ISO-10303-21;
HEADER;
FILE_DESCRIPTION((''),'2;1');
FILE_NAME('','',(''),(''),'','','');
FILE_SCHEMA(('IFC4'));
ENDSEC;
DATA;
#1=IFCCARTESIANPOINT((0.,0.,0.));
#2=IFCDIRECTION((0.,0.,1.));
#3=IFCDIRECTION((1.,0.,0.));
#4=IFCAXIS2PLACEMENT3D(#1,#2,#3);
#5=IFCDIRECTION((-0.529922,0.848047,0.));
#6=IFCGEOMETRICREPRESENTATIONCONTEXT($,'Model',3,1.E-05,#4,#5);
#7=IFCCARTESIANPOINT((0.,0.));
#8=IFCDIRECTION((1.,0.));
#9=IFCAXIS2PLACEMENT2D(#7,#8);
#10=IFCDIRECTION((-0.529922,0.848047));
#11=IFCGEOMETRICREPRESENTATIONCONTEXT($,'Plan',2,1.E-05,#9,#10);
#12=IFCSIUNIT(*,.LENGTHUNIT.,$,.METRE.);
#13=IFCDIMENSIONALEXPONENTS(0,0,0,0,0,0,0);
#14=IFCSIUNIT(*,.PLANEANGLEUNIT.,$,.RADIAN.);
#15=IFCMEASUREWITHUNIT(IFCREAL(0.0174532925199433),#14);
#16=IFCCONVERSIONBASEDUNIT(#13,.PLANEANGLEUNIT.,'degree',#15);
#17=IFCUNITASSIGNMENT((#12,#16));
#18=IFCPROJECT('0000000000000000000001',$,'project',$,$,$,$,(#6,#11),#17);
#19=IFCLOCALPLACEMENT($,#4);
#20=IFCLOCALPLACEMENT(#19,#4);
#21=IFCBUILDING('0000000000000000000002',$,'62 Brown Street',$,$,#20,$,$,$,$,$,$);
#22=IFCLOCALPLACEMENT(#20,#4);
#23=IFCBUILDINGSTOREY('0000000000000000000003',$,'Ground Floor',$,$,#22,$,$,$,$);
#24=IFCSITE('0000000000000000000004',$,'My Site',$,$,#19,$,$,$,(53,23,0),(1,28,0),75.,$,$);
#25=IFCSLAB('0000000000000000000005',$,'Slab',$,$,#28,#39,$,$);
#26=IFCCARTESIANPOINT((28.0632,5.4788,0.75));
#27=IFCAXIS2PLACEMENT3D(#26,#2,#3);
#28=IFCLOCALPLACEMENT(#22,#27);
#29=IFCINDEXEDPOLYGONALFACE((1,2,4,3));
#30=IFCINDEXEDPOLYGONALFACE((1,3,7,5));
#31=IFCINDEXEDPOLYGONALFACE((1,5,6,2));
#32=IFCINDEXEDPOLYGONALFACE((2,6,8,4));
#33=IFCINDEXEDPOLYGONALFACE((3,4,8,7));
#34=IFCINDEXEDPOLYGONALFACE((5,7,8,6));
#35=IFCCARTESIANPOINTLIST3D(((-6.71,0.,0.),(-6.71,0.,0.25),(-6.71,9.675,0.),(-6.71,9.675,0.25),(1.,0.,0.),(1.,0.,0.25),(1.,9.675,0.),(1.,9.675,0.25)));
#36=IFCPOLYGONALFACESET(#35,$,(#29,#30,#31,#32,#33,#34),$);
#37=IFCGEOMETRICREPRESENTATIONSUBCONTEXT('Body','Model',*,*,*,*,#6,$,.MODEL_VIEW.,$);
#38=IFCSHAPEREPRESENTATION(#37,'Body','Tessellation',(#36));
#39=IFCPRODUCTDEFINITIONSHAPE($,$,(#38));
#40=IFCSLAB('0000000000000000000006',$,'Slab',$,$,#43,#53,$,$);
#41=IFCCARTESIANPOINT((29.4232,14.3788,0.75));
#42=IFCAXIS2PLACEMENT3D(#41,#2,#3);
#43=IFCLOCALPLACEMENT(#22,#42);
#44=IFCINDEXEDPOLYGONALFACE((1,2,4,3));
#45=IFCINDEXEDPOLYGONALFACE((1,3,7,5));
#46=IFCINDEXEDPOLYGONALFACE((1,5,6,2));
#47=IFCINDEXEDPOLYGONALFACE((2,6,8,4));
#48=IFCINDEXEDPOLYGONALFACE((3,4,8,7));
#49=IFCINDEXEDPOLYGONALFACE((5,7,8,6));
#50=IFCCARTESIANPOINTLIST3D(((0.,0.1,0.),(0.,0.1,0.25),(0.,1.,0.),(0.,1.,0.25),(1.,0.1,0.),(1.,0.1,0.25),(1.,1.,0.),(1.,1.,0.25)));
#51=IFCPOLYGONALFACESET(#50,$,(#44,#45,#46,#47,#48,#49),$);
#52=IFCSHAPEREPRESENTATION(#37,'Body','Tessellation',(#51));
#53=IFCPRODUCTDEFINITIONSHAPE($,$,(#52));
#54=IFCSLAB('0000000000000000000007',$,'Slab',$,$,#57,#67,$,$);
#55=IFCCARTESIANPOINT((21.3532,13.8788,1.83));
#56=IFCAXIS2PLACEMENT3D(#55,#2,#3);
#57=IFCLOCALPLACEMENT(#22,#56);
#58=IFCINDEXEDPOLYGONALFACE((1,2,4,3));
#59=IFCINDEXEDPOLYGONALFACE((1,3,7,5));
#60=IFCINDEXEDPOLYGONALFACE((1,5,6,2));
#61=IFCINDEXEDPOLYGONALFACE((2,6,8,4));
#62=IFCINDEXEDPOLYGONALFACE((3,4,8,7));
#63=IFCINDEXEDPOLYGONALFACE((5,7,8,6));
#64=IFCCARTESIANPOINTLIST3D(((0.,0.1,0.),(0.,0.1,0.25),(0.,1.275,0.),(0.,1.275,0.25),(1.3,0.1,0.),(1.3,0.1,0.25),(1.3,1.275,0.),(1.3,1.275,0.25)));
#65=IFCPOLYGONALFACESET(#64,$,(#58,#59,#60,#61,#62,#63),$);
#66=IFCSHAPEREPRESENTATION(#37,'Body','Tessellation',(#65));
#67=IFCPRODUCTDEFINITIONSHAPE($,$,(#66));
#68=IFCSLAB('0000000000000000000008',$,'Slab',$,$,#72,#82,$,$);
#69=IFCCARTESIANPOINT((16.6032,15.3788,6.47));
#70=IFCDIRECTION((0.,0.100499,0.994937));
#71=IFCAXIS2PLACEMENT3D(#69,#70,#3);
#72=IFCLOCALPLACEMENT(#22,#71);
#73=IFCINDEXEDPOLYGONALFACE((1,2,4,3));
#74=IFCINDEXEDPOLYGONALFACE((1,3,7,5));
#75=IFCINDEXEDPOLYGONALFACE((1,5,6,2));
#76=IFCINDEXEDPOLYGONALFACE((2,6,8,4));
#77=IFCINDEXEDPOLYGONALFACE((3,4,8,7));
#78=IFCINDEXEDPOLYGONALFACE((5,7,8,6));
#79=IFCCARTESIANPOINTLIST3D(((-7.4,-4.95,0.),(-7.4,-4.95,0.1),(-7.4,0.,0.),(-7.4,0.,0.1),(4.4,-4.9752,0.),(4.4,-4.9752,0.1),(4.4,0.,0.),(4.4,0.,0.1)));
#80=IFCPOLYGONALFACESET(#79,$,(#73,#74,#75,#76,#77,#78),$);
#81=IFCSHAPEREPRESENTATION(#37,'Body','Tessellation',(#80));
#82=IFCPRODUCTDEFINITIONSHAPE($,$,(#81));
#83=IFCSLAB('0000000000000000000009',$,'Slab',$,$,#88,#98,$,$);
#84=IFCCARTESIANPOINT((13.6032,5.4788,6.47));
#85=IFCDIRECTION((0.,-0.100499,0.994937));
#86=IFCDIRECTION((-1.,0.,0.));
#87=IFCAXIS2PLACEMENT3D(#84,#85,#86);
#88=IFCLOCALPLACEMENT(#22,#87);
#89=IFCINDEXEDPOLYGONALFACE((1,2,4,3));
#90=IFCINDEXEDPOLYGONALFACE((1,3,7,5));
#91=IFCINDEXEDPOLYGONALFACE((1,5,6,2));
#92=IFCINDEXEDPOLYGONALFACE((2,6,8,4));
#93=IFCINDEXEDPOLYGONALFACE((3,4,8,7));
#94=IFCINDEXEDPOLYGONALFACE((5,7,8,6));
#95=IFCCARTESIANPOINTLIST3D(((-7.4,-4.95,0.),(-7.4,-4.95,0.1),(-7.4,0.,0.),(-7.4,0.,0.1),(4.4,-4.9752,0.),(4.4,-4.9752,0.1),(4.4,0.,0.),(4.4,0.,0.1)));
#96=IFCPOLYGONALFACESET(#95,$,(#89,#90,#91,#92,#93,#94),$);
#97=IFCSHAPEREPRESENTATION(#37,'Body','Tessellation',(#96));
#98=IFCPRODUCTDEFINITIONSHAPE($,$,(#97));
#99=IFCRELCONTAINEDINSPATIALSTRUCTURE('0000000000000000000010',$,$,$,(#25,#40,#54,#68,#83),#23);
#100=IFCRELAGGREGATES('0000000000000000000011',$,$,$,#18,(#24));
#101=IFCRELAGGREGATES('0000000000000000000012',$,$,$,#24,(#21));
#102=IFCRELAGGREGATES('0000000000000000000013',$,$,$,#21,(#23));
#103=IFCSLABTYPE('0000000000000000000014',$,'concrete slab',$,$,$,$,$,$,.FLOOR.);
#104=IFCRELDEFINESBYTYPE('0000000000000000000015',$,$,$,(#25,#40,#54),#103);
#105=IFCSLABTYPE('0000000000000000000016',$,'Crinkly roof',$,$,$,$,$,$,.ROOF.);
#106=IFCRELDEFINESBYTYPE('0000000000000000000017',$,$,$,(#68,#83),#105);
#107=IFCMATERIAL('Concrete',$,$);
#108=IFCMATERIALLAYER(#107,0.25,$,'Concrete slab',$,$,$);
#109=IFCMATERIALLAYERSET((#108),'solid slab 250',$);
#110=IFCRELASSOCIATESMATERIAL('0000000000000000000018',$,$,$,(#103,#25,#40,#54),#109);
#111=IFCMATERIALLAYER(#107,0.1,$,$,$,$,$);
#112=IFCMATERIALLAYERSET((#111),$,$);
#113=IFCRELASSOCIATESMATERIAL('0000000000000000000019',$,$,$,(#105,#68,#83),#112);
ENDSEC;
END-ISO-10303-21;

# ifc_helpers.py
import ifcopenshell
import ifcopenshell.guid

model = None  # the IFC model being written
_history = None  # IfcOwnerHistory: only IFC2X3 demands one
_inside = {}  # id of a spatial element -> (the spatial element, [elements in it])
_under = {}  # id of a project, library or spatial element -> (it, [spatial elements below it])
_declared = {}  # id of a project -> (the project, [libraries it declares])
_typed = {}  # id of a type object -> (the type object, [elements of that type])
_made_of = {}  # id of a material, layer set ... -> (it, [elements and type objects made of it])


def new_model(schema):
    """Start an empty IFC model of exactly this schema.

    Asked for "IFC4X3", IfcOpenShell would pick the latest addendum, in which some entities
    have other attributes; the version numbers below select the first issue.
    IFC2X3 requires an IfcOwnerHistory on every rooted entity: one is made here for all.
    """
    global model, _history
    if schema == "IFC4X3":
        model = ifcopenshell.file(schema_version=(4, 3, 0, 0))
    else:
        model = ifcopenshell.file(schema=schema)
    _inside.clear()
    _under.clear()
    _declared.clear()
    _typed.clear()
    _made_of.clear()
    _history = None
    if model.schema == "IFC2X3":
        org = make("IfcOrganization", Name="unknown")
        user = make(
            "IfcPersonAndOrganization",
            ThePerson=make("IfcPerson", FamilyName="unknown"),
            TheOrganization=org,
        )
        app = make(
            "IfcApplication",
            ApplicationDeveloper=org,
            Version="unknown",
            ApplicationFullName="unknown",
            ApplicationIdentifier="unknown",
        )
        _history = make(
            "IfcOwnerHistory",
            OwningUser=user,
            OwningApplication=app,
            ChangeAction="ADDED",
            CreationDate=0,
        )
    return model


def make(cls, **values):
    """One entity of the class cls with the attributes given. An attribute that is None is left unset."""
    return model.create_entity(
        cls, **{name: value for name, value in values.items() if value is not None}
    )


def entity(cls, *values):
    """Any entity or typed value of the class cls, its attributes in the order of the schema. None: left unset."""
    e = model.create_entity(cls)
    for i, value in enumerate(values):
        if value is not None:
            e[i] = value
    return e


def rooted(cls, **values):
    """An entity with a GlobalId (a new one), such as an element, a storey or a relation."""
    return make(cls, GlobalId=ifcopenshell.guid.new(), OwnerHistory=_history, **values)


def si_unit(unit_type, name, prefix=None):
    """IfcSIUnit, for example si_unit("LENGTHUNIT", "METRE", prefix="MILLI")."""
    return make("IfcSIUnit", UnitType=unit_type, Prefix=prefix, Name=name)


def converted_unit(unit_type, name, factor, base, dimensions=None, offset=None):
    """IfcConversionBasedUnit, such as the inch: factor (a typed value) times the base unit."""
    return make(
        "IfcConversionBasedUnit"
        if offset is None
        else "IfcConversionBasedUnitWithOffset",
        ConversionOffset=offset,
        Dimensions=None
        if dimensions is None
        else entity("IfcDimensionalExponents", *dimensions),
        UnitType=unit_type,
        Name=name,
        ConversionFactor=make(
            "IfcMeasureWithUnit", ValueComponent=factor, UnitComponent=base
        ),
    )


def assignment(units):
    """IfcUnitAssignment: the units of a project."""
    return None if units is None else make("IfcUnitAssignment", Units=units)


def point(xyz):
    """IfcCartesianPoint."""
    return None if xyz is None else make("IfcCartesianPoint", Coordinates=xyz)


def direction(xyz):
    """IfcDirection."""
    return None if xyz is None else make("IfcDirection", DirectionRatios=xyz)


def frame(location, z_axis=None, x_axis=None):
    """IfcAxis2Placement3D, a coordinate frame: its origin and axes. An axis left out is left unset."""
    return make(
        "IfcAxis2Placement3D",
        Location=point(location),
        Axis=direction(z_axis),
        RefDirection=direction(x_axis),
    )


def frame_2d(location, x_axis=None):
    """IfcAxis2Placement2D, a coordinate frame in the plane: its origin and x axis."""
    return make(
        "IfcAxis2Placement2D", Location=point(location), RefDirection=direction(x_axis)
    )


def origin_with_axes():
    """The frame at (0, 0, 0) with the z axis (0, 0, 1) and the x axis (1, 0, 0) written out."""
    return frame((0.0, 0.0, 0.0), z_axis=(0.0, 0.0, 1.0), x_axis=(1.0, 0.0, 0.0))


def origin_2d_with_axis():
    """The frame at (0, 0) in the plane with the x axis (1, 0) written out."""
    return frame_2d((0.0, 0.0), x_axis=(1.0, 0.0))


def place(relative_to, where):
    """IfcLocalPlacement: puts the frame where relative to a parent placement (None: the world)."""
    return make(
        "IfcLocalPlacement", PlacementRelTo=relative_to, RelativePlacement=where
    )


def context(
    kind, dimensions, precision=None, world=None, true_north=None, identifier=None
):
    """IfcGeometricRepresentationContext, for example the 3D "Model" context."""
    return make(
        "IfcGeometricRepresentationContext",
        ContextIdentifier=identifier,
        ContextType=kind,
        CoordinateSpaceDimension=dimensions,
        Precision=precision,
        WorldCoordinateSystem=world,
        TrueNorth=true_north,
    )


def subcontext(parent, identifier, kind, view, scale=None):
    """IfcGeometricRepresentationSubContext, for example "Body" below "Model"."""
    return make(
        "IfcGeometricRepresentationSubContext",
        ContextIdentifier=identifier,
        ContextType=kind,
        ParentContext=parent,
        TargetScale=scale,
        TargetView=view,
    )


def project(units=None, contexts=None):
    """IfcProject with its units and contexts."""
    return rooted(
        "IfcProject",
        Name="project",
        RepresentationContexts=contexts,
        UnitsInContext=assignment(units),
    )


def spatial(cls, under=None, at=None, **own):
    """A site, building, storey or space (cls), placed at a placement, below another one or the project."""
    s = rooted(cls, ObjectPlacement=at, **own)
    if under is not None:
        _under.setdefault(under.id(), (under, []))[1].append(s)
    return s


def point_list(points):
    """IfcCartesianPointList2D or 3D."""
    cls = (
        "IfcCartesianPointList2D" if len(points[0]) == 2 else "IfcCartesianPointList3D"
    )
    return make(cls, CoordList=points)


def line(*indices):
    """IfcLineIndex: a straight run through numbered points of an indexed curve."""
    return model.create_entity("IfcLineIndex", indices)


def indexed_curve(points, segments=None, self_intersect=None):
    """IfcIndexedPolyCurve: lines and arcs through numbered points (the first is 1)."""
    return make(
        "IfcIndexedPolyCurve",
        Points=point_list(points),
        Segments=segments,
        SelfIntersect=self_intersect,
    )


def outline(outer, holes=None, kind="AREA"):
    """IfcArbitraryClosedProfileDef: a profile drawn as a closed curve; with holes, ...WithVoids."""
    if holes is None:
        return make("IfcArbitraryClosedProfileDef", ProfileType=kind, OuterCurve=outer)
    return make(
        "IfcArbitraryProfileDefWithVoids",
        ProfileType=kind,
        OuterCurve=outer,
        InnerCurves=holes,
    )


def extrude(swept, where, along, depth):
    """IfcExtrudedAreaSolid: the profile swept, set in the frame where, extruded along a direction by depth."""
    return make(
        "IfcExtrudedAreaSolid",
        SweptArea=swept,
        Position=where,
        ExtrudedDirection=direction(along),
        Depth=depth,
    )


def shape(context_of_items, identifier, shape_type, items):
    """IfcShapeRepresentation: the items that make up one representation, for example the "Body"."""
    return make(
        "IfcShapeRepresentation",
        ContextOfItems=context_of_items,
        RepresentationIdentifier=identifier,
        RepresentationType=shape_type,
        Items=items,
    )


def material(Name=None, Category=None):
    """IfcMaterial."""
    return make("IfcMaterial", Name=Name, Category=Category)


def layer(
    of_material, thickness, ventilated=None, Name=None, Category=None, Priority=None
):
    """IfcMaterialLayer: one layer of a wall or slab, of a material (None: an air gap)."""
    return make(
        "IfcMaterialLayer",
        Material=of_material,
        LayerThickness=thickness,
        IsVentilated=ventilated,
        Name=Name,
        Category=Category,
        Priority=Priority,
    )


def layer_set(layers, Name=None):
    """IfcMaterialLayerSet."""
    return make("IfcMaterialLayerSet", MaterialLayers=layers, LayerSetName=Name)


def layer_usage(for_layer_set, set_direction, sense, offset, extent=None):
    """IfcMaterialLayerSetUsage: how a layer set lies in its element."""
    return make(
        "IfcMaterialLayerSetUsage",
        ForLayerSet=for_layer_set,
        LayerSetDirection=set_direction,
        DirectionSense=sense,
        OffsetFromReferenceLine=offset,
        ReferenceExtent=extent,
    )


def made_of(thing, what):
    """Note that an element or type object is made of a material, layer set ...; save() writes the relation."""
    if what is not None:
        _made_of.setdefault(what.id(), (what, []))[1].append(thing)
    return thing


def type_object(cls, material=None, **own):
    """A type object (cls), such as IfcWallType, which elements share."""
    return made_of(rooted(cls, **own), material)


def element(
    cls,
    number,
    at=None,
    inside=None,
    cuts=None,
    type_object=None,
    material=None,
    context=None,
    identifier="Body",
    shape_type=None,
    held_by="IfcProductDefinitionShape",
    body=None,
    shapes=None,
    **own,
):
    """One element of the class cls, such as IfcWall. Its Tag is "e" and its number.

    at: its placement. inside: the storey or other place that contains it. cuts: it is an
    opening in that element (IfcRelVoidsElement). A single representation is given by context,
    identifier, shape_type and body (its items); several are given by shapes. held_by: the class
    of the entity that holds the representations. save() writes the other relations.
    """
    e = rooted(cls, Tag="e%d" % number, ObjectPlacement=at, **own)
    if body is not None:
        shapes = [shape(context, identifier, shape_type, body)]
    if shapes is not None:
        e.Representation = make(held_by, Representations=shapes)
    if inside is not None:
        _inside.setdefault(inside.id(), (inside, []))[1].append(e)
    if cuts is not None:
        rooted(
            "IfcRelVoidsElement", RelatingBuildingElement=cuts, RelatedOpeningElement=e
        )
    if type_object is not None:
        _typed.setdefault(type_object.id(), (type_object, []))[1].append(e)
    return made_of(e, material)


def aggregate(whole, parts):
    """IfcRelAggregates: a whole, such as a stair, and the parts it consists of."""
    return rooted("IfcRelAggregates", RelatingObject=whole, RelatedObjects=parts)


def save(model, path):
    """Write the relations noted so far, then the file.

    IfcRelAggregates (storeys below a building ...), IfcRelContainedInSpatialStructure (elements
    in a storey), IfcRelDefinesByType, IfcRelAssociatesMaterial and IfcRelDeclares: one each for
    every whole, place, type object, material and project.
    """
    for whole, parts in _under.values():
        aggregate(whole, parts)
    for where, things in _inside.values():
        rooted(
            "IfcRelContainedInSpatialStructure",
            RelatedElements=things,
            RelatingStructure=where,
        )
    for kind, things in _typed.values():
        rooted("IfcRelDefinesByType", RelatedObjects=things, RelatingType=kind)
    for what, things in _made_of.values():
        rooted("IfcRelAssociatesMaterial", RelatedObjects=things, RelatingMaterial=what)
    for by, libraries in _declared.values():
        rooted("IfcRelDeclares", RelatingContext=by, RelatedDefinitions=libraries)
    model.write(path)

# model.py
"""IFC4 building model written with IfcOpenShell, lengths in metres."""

from ifc_helpers import new_model, entity, si_unit, converted_unit, direction, frame, origin_with_axes, origin_2d_with_axis, place, context, subcontext, project, spatial, line, indexed_curve, outline, extrude, material, layer, layer_set, layer_usage, type_object, element, save


model = new_model("IFC4")

# Units and contexts
model_context = context("Model", 3, precision=1e-05, world=origin_with_axes(), true_north=direction((-0.529922, 0.848047, 0.0)))
plan_context = context("Plan", 2, precision=1e-05, world=origin_2d_with_axis(), true_north=direction((-0.529922, 0.848047)))
body_context = subcontext(model_context, "Body", "Model", "MODEL_VIEW")
ifc_project = project(units=[si_unit("LENGTHUNIT", "METRE"), converted_unit("PLANEANGLEUNIT", "degree", entity("IfcReal", 0.0174532925199433), si_unit("PLANEANGLEUNIT", "RADIAN"), dimensions=[0, 0, 0, 0, 0, 0, 0])], contexts=[model_context, plan_context])

# Site, building, storey
site_placement = place(None, origin_with_axes())
site = spatial("IfcSite", under=ifc_project, at=site_placement, Name="My Site", RefLatitude=(53, 23, 0), RefLongitude=(1, 28, 0), RefElevation=75.0)
building_placement = place(site_placement, origin_with_axes())
building = spatial("IfcBuilding", under=site, at=building_placement, Name="62 Brown Street")
storey_placement = place(building_placement, origin_with_axes())
storey = spatial("IfcBuildingStorey", under=building, at=storey_placement, Name="Ground Floor")

# Shared definitions
ifc_material_1 = material(Name="Concrete")

# Slabs
ifc_layer_1 = layer(ifc_material_1, 0.25, Name="Concrete slab")
ifc_layer_set_1 = layer_set([ifc_layer_1], Name="solid slab 250")
slab_type_1 = type_object("IfcSlabType", Name="concrete slab", PredefinedType="FLOOR", material=ifc_layer_set_1)
ifc_layer_usage_1 = layer_usage(ifc_layer_set_1, "AXIS3", "POSITIVE", 0.0)
slab_1_placement = place(storey_placement, frame((28.0632, 5.4788, 0.75), z_axis=(0.0, 0.0, 1.0), x_axis=(1.0, 0.0, 0.0)))
element("IfcSlab", 1, at=slab_1_placement, inside=storey, type_object=slab_type_1, material=ifc_layer_usage_1, Name="Slab", context=body_context, shape_type="SweptSolid", body=[
    extrude(outline(indexed_curve([(-6.71, 0.0), (-6.71, 9.675), (1.0, 9.675), (1.0, 0.0), (-6.71, 0.0)])), None, (0.0, 0.0, 1.0), 0.25),
])
ifc_layer_usage_2 = layer_usage(ifc_layer_set_1, "AXIS3", "POSITIVE", 0.0)
slab_2_placement = place(storey_placement, frame((29.4232, 14.3788, 0.75), z_axis=(0.0, 0.0, 1.0), x_axis=(1.0, 0.0, 0.0)))
element("IfcSlab", 2, at=slab_2_placement, inside=storey, type_object=slab_type_1, material=ifc_layer_usage_2, Name="Slab", context=body_context, shape_type="SweptSolid", body=[
    extrude(outline(indexed_curve([(1.0, 1.0), (1.0, 0.1), (0.0, 0.1), (0.0, 1.0)], segments=[line(3, 2), line(2, 1), line(1, 4), line(4, 3)], self_intersect=False)), None, (0.0, 0.0, 1.0), 0.25),
])
ifc_layer_usage_3 = layer_usage(ifc_layer_set_1, "AXIS3", "POSITIVE", 0.0)
slab_3_placement = place(storey_placement, frame((21.3532, 13.8788, 1.83), z_axis=(0.0, 0.0, 1.0), x_axis=(1.0, 0.0, 0.0)))
element("IfcSlab", 3, at=slab_3_placement, inside=storey, type_object=slab_type_1, material=ifc_layer_usage_3, Name="Slab", context=body_context, shape_type="SweptSolid", body=[
    extrude(outline(indexed_curve([(0.0, 0.1), (1.3, 0.1), (1.3, 1.275), (0.0, 1.275), (0.0, 0.1)])), None, (0.0, 0.0, 1.0), 0.25),
])
ifc_layer_2 = layer(ifc_material_1, 0.1)
ifc_layer_set_2 = layer_set([ifc_layer_2])
ifc_layer_usage_4 = layer_usage(ifc_layer_set_2, "AXIS3", "POSITIVE", 0.0)
slab_type_2 = type_object("IfcSlabType", Name="Crinkly roof", PredefinedType="ROOF", material=ifc_layer_set_2)
slab_4_placement = place(storey_placement, frame((16.6032, 15.3788, 6.47), z_axis=(0.0, 0.100499, 0.994937), x_axis=(1.0, 0.0, 0.0)))
element("IfcSlab", 4, at=slab_4_placement, inside=storey, type_object=slab_type_2, material=ifc_layer_usage_4, Name="Slab", context=body_context, shape_type="SweptSolid", body=[
    extrude(outline(indexed_curve([(4.4, 0.0), (-7.4, 0.0), (-7.4, -4.95), (4.4, -4.9752), (4.4, 0.0)])), None, (0.0, 0.0, 1.0), 0.1),
])
ifc_layer_usage_5 = layer_usage(ifc_layer_set_2, "AXIS3", "POSITIVE", 0.0)
slab_5_placement = place(storey_placement, frame((13.6032, 5.4788, 6.47), z_axis=(0.0, -0.100499, 0.994937), x_axis=(-1.0, 0.0, 0.0)))
element("IfcSlab", 5, at=slab_5_placement, inside=storey, type_object=slab_type_2, material=ifc_layer_usage_5, Name="Slab", context=body_context, shape_type="SweptSolid", body=[
    extrude(outline(indexed_curve([(4.4, 0.0), (-7.4, 0.0), (-7.4, -4.95), (4.4, -4.9752), (4.4, 0.0)])), None, (0.0, 0.0, 1.0), 0.1),
])

save(model, "model.ifc")
